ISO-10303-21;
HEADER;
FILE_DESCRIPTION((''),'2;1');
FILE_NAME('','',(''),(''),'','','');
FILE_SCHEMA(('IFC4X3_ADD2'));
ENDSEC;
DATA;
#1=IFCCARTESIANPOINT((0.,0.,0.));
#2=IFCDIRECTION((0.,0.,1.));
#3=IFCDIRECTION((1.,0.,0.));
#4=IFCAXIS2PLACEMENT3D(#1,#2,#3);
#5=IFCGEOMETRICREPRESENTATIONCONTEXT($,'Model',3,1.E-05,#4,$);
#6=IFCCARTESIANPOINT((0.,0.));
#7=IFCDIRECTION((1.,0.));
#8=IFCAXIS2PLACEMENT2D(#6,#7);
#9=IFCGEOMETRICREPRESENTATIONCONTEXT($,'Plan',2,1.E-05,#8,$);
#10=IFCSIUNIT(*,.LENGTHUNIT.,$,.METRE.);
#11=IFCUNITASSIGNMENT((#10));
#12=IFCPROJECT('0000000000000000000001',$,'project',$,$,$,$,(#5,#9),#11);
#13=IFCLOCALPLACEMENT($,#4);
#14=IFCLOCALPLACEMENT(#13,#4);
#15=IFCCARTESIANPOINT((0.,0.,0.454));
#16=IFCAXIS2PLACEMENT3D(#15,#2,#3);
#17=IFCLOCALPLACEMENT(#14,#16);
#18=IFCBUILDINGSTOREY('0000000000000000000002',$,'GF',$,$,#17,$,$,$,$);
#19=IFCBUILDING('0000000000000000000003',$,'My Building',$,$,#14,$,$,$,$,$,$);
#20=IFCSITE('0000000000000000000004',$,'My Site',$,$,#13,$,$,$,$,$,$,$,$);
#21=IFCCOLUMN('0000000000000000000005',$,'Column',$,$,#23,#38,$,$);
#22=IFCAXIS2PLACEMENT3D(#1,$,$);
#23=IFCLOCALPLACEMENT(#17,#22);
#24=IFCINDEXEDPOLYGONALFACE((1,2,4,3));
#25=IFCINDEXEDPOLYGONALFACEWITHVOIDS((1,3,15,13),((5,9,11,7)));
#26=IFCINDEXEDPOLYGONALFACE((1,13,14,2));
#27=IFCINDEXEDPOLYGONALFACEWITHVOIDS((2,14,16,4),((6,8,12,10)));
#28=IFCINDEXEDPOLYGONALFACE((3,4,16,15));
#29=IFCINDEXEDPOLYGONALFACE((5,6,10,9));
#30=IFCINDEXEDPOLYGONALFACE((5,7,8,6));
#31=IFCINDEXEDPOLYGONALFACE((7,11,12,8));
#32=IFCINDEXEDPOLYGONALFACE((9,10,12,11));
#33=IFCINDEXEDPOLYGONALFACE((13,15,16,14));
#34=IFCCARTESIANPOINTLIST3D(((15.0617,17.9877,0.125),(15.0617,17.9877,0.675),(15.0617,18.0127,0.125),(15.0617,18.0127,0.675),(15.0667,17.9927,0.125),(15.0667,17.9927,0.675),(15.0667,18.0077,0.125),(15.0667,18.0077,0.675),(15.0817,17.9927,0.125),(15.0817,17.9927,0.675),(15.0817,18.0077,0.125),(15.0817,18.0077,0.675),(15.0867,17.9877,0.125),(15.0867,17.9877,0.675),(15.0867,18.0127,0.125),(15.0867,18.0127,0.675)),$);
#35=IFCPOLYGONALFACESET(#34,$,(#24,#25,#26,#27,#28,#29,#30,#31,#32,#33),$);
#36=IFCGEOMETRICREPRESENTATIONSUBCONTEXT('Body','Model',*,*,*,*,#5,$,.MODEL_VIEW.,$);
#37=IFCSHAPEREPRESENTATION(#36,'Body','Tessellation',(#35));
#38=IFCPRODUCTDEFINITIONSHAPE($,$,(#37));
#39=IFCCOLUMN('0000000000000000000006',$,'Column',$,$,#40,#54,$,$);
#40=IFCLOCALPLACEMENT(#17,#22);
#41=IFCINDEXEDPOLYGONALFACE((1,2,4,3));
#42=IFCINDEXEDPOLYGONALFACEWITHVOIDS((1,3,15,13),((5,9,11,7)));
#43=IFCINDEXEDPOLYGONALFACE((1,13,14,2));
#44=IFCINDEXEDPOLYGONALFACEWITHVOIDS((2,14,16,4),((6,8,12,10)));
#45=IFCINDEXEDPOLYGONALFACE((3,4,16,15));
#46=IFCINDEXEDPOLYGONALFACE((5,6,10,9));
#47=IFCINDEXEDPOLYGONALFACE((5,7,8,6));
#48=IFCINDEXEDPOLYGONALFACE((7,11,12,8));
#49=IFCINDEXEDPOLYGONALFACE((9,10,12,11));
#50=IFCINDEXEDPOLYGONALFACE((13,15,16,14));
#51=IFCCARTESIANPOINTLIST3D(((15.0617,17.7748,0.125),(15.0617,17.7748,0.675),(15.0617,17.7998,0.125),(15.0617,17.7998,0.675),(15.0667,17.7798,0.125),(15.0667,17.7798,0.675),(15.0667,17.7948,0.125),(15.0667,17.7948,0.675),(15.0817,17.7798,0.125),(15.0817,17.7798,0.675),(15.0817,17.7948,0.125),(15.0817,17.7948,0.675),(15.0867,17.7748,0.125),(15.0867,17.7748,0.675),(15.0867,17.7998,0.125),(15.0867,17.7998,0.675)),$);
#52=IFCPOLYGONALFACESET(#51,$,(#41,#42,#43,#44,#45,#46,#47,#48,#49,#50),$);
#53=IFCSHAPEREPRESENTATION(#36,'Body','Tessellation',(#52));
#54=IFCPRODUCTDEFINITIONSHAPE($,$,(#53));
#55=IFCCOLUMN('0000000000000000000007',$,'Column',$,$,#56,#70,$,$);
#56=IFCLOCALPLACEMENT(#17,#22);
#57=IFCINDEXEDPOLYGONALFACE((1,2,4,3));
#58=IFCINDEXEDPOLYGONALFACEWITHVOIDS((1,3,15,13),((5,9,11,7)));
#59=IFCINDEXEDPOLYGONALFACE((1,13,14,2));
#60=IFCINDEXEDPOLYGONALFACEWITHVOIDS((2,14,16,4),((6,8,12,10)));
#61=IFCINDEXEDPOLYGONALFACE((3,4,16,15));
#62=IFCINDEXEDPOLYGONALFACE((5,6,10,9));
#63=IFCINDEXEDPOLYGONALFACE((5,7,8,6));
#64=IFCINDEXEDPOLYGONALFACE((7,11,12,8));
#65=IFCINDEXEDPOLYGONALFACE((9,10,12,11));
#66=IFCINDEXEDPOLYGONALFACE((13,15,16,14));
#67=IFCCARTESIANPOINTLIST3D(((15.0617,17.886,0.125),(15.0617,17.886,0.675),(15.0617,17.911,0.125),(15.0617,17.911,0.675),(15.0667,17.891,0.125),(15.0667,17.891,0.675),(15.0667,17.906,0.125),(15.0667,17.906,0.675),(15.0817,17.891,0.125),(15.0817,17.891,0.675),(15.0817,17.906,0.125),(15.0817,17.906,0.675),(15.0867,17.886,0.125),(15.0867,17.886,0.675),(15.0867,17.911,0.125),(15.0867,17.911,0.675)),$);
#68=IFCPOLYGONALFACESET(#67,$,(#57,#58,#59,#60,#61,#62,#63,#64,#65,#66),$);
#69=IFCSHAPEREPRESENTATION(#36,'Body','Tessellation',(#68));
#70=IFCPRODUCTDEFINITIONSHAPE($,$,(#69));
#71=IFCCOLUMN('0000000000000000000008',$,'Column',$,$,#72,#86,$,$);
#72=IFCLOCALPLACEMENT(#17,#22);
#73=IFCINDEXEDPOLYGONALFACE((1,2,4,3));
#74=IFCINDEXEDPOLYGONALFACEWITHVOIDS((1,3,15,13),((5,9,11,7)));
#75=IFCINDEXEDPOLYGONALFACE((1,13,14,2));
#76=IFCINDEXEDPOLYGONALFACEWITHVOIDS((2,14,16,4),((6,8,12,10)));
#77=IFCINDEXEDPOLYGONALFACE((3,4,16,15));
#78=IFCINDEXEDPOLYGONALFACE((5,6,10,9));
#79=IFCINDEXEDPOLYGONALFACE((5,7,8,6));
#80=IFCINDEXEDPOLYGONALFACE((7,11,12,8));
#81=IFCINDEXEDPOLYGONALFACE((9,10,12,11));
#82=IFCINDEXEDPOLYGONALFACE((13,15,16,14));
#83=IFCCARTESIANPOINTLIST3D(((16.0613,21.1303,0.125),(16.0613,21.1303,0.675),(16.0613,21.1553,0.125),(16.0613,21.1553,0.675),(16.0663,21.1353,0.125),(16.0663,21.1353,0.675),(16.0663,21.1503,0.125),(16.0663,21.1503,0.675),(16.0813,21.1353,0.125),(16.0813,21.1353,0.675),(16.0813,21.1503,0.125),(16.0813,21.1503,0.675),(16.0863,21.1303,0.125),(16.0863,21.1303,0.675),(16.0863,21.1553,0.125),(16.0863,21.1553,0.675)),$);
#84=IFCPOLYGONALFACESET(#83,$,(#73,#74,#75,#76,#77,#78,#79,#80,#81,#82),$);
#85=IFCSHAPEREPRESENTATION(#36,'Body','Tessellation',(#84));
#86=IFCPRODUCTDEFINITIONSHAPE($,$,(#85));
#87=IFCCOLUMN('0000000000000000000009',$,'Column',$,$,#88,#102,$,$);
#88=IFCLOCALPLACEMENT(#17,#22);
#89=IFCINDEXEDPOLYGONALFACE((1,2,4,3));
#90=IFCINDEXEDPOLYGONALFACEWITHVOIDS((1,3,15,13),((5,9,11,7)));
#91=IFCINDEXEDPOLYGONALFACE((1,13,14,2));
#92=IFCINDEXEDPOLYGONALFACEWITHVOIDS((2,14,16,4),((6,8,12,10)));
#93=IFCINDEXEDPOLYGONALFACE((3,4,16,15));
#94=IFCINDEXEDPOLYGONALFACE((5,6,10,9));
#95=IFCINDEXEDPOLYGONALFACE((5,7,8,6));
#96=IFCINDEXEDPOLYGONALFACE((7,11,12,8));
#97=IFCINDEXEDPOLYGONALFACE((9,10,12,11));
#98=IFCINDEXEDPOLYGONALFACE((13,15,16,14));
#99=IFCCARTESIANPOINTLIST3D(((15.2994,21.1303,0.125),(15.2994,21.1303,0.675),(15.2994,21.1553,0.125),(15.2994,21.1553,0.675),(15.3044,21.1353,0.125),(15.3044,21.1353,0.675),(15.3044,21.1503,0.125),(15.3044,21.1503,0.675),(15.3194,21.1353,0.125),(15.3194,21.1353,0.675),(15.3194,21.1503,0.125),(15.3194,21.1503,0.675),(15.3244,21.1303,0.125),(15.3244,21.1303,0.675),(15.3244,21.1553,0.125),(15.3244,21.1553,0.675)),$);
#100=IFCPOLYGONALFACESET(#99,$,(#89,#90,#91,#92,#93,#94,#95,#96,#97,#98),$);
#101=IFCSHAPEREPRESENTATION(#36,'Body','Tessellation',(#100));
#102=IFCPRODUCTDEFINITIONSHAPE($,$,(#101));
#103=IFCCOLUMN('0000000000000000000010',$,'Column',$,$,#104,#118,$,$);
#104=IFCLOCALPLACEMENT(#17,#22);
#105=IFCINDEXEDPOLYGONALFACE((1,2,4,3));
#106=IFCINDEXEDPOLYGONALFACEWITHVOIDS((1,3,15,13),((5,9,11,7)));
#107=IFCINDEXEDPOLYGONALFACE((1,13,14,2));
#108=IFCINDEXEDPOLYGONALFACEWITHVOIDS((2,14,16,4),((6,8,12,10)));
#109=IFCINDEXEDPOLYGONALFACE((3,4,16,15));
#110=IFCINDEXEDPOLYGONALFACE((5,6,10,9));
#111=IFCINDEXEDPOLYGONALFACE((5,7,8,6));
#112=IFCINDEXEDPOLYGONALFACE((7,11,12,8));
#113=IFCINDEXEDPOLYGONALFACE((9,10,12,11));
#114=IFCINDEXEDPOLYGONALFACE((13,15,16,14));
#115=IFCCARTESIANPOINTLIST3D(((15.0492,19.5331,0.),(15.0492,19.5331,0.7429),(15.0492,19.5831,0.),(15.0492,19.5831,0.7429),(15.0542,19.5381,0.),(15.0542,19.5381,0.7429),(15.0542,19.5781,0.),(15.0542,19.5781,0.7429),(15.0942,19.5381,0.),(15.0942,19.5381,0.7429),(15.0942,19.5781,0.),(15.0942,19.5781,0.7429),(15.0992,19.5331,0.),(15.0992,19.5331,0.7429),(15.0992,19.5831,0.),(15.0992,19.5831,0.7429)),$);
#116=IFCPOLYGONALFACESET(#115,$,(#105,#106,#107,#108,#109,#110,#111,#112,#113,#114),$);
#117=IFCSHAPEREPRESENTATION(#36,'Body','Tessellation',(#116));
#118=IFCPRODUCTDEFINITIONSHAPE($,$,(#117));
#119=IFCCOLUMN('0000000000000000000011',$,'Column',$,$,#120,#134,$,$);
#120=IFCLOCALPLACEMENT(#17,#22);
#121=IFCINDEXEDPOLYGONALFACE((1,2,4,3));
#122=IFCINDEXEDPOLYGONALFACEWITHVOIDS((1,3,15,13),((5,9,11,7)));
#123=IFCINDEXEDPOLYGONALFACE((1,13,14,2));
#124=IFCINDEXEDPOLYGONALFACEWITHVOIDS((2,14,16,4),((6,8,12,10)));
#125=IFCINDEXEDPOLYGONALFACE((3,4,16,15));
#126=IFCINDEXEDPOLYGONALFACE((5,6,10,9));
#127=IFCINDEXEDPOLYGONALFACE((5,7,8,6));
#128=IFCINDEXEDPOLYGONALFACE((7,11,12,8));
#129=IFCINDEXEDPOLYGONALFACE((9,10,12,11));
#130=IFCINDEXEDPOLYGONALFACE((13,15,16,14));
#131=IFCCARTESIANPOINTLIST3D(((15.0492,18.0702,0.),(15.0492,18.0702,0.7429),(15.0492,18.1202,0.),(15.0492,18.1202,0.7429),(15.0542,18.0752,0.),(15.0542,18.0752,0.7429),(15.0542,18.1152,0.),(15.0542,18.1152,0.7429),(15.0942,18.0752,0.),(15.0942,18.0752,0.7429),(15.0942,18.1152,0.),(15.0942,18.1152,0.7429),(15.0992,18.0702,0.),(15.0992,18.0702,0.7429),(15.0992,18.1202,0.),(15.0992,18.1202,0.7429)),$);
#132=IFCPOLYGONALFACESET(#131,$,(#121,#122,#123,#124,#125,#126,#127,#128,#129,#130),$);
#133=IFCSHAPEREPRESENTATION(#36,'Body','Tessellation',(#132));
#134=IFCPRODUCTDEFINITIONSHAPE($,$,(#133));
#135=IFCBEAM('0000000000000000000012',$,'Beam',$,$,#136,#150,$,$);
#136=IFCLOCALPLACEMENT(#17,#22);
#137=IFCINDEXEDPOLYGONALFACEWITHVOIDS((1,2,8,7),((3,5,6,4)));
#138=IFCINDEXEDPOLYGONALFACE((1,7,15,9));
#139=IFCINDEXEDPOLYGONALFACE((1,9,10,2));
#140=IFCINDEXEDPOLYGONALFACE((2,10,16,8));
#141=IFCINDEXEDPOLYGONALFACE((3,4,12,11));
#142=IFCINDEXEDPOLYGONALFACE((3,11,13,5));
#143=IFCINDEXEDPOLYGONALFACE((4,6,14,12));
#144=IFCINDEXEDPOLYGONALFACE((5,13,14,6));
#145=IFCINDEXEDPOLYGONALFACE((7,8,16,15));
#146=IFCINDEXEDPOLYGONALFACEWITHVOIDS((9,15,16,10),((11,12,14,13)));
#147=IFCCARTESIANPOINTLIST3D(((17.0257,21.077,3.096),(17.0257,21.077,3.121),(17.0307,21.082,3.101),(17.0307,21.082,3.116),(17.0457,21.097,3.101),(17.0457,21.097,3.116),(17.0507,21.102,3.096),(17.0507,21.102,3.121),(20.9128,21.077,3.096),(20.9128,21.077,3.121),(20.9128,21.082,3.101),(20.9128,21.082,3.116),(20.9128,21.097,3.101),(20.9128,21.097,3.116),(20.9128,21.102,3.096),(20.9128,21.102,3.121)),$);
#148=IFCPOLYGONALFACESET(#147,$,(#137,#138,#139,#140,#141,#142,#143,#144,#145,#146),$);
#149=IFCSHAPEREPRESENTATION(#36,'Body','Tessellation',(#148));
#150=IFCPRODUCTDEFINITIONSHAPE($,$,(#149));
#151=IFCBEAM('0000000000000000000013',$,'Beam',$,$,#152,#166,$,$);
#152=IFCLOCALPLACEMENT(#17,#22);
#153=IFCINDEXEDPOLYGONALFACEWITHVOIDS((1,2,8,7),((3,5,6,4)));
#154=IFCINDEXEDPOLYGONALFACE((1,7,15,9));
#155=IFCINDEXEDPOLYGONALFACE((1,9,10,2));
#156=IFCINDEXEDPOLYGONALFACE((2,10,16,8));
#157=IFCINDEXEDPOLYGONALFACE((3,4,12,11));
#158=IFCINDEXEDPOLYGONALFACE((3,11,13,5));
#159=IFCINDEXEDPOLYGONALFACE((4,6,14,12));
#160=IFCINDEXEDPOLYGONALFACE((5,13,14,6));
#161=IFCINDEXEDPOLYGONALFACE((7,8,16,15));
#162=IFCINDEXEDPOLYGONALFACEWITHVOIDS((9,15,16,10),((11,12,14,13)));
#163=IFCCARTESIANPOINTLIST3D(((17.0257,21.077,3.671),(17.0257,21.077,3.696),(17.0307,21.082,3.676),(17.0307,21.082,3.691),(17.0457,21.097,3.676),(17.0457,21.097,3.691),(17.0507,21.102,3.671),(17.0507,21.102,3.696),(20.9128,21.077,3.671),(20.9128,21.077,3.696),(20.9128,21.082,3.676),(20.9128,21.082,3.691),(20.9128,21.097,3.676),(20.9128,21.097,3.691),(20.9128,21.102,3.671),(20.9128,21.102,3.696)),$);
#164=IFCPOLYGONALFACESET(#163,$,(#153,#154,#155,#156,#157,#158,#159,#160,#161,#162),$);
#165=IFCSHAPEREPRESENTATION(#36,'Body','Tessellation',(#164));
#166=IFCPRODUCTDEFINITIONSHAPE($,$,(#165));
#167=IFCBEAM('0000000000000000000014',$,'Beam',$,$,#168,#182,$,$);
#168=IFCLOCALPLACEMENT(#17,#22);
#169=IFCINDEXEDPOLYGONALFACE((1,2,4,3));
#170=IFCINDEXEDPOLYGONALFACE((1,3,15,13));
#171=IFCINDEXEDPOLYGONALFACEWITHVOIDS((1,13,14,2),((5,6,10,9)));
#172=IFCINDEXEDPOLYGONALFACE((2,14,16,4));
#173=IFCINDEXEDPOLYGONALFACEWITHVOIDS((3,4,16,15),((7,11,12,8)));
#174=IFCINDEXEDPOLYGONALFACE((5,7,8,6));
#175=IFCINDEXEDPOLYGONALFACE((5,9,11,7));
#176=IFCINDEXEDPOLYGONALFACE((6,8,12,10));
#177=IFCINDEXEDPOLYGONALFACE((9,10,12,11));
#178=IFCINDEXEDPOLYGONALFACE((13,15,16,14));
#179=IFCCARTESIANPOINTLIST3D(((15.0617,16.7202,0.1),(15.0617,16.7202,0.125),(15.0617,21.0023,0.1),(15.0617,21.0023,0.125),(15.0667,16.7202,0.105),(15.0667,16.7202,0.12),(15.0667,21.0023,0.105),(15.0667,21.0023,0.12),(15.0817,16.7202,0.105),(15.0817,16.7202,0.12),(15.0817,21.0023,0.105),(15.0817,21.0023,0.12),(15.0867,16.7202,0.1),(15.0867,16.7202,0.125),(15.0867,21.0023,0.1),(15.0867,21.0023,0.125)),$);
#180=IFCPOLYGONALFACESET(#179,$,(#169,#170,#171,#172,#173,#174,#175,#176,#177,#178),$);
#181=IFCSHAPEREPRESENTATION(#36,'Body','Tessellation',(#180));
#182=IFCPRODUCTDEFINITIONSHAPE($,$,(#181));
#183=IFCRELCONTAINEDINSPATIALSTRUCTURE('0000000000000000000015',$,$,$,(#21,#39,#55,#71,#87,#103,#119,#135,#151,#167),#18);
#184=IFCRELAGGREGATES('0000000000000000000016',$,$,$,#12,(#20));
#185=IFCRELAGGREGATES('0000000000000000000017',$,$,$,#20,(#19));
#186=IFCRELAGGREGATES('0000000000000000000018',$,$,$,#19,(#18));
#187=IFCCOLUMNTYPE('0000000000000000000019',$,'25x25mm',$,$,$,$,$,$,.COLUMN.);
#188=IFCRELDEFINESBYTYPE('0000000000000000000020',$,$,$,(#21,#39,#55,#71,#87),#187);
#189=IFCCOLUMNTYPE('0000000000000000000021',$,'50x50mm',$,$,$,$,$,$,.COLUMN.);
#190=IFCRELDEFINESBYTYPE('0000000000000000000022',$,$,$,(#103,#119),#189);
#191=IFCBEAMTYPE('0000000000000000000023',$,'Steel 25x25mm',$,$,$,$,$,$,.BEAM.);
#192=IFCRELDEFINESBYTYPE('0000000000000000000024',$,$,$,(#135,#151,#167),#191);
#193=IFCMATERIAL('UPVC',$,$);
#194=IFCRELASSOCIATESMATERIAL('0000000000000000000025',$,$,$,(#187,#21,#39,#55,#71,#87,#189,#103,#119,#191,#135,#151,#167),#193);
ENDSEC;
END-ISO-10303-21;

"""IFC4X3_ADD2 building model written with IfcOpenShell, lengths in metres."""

from ifc_helpers import new_model, si_unit, frame, origin_with_axes, origin_2d_with_axis, place, context, subcontext, project, spatial, hollow_rectangle, extrude, clip, halfspace, material, material_profile, profile_set, profile_usage, type_object, element, save


model = new_model("IFC4X3_ADD2")

# Units and contexts
model_context = context("Model", 3, precision=1e-05, world=origin_with_axes())
plan_context = context("Plan", 2, precision=1e-05, world=origin_2d_with_axis())
body_context = subcontext(model_context, "Body", "Model", "MODEL_VIEW")
ifc_project = project(units=[si_unit("LENGTHUNIT", "METRE")], contexts=[model_context, plan_context])

# Site, building, storey
site_placement = place(None, origin_with_axes())
site = spatial("IfcSite", under=ifc_project, at=site_placement, Name="My Site")
building_placement = place(site_placement, origin_with_axes())
building = spatial("IfcBuilding", under=site, at=building_placement, Name="My Building")
storey_placement = place(building_placement, frame((0.0, 0.0, 0.454), z_axis=(0.0, 0.0, 1.0), x_axis=(1.0, 0.0, 0.0)))
storey = spatial("IfcBuildingStorey", under=building, at=storey_placement, Name="GF")

# Columns
ifc_material_1 = material(Name="UPVC")
ifc_material_profile_1 = material_profile(ifc_material_1, hollow_rectangle(XDim=0.025, YDim=0.025, WallThickness=0.005))
ifc_profile_set_1 = profile_set([ifc_material_profile_1])
column_type_1 = type_object("IfcColumnType", Name="25x25mm", PredefinedType="COLUMN", material=ifc_profile_set_1)
ifc_profile_usage_1 = profile_usage(ifc_profile_set_1)
column_1_placement = place(storey_placement, frame((15.0742, 18.0002, 0.125), z_axis=(0.0, 0.0, 1.0), x_axis=(0.0, -1.0, 0.0)))
element("IfcColumn", 1, at=column_1_placement, inside=storey, type_object=column_type_1, material=ifc_profile_usage_1, Name="Column", context=body_context, shape_type="SweptSolid", body=[
    extrude(hollow_rectangle(XDim=0.025, YDim=0.025, WallThickness=0.005), origin_with_axes(), (0.0, 0.0, 1.0), 0.55),
])
ifc_profile_usage_2 = profile_usage(ifc_profile_set_1)
column_2_placement = place(storey_placement, frame((15.0742, 17.7873, 0.125), z_axis=(0.0, 0.0, 1.0), x_axis=(0.0, -1.0, 0.0)))
element("IfcColumn", 2, at=column_2_placement, inside=storey, type_object=column_type_1, material=ifc_profile_usage_2, Name="Column", context=body_context, shape_type="SweptSolid", body=[
    extrude(hollow_rectangle(XDim=0.025, YDim=0.025, WallThickness=0.005), origin_with_axes(), (0.0, 0.0, 1.0), 0.55),
])
ifc_profile_usage_3 = profile_usage(ifc_profile_set_1)
column_3_placement = place(storey_placement, frame((15.0742, 17.8985, 0.125), z_axis=(0.0, 0.0, 1.0), x_axis=(0.0, -1.0, 0.0)))
element("IfcColumn", 3, at=column_3_placement, inside=storey, type_object=column_type_1, material=ifc_profile_usage_3, Name="Column", context=body_context, shape_type="SweptSolid", body=[
    extrude(hollow_rectangle(XDim=0.025, YDim=0.025, WallThickness=0.005), origin_with_axes(), (0.0, 0.0, 1.0), 0.55),
])
ifc_profile_usage_4 = profile_usage(ifc_profile_set_1)
column_4_placement = place(storey_placement, frame((16.0738, 21.1428, 0.125), z_axis=(0.0, 0.0, 1.0), x_axis=(0.0, -1.0, 0.0)))
element("IfcColumn", 4, at=column_4_placement, inside=storey, type_object=column_type_1, material=ifc_profile_usage_4, Name="Column", context=body_context, shape_type="SweptSolid", body=[
    extrude(hollow_rectangle(XDim=0.025, YDim=0.025, WallThickness=0.005), origin_with_axes(), (0.0, 0.0, 1.0), 0.55),
])
ifc_profile_usage_5 = profile_usage(ifc_profile_set_1)
column_5_placement = place(storey_placement, frame((15.3119, 21.1428, 0.125), z_axis=(0.0, 0.0, 1.0), x_axis=(0.0, -1.0, 0.0)))
element("IfcColumn", 5, at=column_5_placement, inside=storey, type_object=column_type_1, material=ifc_profile_usage_5, Name="Column", context=body_context, shape_type="SweptSolid", body=[
    extrude(hollow_rectangle(XDim=0.025, YDim=0.025, WallThickness=0.005), origin_with_axes(), (0.0, 0.0, 1.0), 0.55),
])
ifc_material_profile_2 = material_profile(ifc_material_1, hollow_rectangle(XDim=0.05, YDim=0.05, WallThickness=0.005))
ifc_profile_set_2 = profile_set([ifc_material_profile_2])
ifc_profile_usage_6 = profile_usage(ifc_profile_set_2)
column_type_2 = type_object("IfcColumnType", Name="50x50mm", PredefinedType="COLUMN", material=ifc_profile_set_2)
column_6_placement = place(storey_placement, frame((15.0742, 19.5581, 0.0), z_axis=(0.0, 0.0, 1.0), x_axis=(0.0, -1.0, 0.0)))
element("IfcColumn", 6, at=column_6_placement, inside=storey, type_object=column_type_2, material=ifc_profile_usage_6, Name="Column", context=body_context, shape_type="SweptSolid", body=[
    extrude(hollow_rectangle(XDim=0.05, YDim=0.05, WallThickness=0.005), origin_with_axes(), (0.0, 0.0, 1.0), 0.7429),
])
ifc_profile_usage_7 = profile_usage(ifc_profile_set_2)
column_7_placement = place(storey_placement, frame((15.0742, 18.0952, 0.0), z_axis=(0.0, 0.0, 1.0), x_axis=(0.0, -1.0, 0.0)))
element("IfcColumn", 7, at=column_7_placement, inside=storey, type_object=column_type_2, material=ifc_profile_usage_7, Name="Column", context=body_context, shape_type="SweptSolid", body=[
    extrude(hollow_rectangle(XDim=0.05, YDim=0.05, WallThickness=0.005), origin_with_axes(), (0.0, 0.0, 1.0), 0.7429),
])

# Beams
ifc_material_profile_3 = material_profile(ifc_material_1, hollow_rectangle(XDim=0.025, YDim=0.025, WallThickness=0.005))
ifc_profile_set_3 = profile_set([ifc_material_profile_3])
ifc_profile_usage_8 = profile_usage(ifc_profile_set_3)
beam_type_1 = type_object("IfcBeamType", Name="Steel 25x25mm", PredefinedType="BEAM", material=ifc_profile_set_3)
beam_1_placement = place(storey_placement, frame((17.0257, 21.0895, 3.1085), z_axis=(1.0, 0.0, 0.0), x_axis=(0.0, 1.0, 0.0)))
element("IfcBeam", 8, at=beam_1_placement, inside=storey, type_object=beam_type_1, material=ifc_profile_usage_8, Name="Beam", context=body_context, shape_type="Clipping", body=[
    clip(extrude(hollow_rectangle(XDim=0.025, YDim=0.025, WallThickness=0.005), origin_with_axes(), (0.0, 0.0, 1.0), 3.8871), halfspace(frame((-0.0125, -3.5625, 0.0), z_axis=(0.707134, 0.0, -0.70708), x_axis=(0.0, -1.0, 0.0)), False)),
])
ifc_profile_usage_9 = profile_usage(ifc_profile_set_3)
beam_2_placement = place(storey_placement, frame((17.0257, 21.0895, 3.6835), z_axis=(1.0, 0.0, 0.0), x_axis=(0.0, 1.0, 0.0)))
element("IfcBeam", 9, at=beam_2_placement, inside=storey, type_object=beam_type_1, material=ifc_profile_usage_9, Name="Beam", context=body_context, shape_type="Clipping", body=[
    clip(extrude(hollow_rectangle(XDim=0.025, YDim=0.025, WallThickness=0.005), origin_with_axes(), (0.0, 0.0, 1.0), 3.8871), halfspace(frame((-0.0125, -4.1375, 0.0), z_axis=(0.707134, 0.0, -0.70708), x_axis=(0.0, -1.0, 0.0)), False)),
])
ifc_profile_usage_10 = profile_usage(ifc_profile_set_3)
beam_3_placement = place(storey_placement, frame((15.0742, 21.0023, 0.1125), z_axis=(0.0, -1.0, 0.0), x_axis=(1.0, 0.0, 0.0)))
element("IfcBeam", 10, at=beam_3_placement, inside=storey, type_object=beam_type_1, material=ifc_profile_usage_10, Name="Beam", context=body_context, shape_type="SweptSolid", body=[
    extrude(hollow_rectangle(XDim=0.025, YDim=0.025, WallThickness=0.005), origin_with_axes(), (0.0, 0.0, 1.0), 4.2821),
])

save(model, "model.ifc")
